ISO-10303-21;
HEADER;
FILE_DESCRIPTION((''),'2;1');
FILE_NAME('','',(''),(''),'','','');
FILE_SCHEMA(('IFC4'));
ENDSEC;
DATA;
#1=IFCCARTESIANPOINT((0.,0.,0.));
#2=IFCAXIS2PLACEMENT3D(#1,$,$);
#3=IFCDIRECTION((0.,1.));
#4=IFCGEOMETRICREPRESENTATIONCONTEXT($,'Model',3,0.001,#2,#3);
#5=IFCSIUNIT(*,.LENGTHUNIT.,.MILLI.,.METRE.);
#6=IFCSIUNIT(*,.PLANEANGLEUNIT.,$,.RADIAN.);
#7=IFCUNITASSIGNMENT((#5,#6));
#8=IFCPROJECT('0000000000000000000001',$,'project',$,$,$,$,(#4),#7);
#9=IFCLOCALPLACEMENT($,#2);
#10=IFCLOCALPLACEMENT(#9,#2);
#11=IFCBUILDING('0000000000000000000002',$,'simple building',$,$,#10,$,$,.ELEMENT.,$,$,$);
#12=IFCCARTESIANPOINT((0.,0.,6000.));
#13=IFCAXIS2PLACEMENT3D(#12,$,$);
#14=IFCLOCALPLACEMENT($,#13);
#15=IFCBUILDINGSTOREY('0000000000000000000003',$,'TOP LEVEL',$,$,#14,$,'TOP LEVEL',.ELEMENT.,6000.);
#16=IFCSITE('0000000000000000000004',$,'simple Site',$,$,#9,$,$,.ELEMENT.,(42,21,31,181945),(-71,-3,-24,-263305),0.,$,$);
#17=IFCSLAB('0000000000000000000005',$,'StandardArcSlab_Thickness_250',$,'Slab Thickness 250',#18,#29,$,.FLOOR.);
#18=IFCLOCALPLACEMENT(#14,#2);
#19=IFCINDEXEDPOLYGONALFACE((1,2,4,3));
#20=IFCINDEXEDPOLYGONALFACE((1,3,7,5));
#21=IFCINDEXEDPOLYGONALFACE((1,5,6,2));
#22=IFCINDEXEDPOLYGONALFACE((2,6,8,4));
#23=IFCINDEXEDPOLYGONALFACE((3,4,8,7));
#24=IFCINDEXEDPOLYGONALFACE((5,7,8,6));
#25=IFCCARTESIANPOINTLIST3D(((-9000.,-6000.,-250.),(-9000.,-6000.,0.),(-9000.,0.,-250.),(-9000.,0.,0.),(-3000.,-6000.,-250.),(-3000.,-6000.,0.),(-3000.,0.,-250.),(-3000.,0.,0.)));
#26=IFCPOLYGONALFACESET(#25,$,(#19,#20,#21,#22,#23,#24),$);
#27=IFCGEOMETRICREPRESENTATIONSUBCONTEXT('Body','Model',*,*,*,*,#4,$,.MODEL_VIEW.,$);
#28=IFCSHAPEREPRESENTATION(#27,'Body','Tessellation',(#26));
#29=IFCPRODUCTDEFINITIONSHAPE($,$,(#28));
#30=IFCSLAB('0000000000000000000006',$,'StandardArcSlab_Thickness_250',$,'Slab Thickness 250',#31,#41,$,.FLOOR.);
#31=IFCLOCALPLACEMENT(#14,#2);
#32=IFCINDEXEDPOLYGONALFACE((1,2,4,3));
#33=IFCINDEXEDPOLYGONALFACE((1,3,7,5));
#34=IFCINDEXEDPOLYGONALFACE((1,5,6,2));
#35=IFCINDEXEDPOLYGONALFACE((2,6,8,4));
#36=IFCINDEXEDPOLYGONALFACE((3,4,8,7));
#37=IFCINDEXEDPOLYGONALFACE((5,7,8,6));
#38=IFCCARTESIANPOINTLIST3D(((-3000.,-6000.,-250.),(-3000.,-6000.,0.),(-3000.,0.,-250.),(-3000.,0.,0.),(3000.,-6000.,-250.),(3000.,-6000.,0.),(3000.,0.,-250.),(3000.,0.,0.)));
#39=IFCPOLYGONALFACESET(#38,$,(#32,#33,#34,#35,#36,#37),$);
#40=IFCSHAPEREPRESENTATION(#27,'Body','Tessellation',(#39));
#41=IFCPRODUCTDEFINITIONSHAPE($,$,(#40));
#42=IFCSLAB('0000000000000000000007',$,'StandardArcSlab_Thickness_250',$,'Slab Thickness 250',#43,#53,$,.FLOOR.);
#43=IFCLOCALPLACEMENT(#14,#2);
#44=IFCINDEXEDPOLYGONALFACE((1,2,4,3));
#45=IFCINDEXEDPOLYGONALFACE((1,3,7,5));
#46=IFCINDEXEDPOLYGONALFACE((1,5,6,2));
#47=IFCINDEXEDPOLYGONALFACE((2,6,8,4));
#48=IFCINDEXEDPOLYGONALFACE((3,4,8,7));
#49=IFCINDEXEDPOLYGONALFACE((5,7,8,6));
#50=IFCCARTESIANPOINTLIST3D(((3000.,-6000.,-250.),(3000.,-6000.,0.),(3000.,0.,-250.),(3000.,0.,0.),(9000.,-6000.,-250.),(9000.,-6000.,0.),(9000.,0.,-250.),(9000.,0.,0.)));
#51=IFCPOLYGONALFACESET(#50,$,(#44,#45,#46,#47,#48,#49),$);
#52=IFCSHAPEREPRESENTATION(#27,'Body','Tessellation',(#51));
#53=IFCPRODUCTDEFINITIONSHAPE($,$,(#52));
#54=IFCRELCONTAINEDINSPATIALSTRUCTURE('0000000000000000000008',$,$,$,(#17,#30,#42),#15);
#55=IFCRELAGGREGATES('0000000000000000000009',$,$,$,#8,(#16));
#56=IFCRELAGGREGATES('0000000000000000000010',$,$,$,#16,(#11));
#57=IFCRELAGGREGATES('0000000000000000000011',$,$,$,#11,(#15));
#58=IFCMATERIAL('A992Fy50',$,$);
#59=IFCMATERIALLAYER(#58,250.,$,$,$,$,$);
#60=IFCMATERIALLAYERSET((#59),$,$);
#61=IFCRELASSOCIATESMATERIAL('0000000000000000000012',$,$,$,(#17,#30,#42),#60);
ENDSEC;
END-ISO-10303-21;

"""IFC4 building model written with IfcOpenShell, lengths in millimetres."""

from ifc_helpers import new_model, si_unit, direction, frame, origin, origin_with_axes, place, context, subcontext, project, spatial, polyline, outline, extrude, material, layer, layer_set, layer_usage, element, save


model = new_model("IFC4")

# Units and contexts
model_context = context("Model", 3, precision=0.001, world=origin(), true_north=direction((0.0, 1.0)))
body_context = subcontext(model_context, "Body", "Model", "MODEL_VIEW")
ifc_project = project(units=[si_unit("LENGTHUNIT", "METRE", prefix="MILLI"), si_unit("PLANEANGLEUNIT", "RADIAN")], contexts=[model_context])

# Site, building, storey
site_placement = place(None, origin())
site = spatial("IfcSite", under=ifc_project, at=site_placement, Name="simple Site", CompositionType="ELEMENT", RefLatitude=(42, 21, 31, 181945), RefLongitude=(-71, -3, -24, -263305), RefElevation=0.0)
building_placement = place(site_placement, origin())
building = spatial("IfcBuilding", under=site, at=building_placement, Name="simple building", CompositionType="ELEMENT")
storey_placement = place(None, frame((0.0, 0.0, 6000.0)))
storey = spatial("IfcBuildingStorey", under=building, at=storey_placement, Name="TOP LEVEL", LongName="TOP LEVEL", CompositionType="ELEMENT", Elevation=6000.0)

# Slabs
ifc_material_1 = material(Name="A992Fy50")
ifc_layer = layer(ifc_material_1, 250.0)
ifc_layer_set = layer_set([ifc_layer])
ifc_layer_usage = layer_usage(ifc_layer_set, "AXIS3", "POSITIVE", -250.0)
for number, where, z_axis, x_axis, name in (
    (1, (-9000.0, -6000.0, 5750.0), (0.0, 0.0, 1.0), (1.0, 0.0, 0.0), "StandardArcSlab_Thickness_250"),
    (2, (-3000.0, -6000.0, 5750.0), (0.0, 0.0, 1.0), (1.0, 0.0, 0.0), "StandardArcSlab_Thickness_250"),
    (3, (3000.0, -6000.0, 5750.0), (0.0, 0.0, 1.0), (1.0, 0.0, 0.0), "StandardArcSlab_Thickness_250"),
):
    element("IfcSlab", number, at=place(None, frame(where, z_axis=z_axis, x_axis=x_axis)), inside=storey, material=ifc_layer_usage, Name=name, ObjectType="Slab Thickness 250", PredefinedType="FLOOR", context=body_context, shape_type="SweptSolid", body=[
        extrude(outline(polyline([(0.0, 0.0), (6000.0, 0.0), (6000.0, 6000.0), (0.0, 6000.0), (0.0, 0.0)])), origin_with_axes(), (0.0, 0.0, 1.0), 250.0),
    ])

save(model, "model.ifc")
